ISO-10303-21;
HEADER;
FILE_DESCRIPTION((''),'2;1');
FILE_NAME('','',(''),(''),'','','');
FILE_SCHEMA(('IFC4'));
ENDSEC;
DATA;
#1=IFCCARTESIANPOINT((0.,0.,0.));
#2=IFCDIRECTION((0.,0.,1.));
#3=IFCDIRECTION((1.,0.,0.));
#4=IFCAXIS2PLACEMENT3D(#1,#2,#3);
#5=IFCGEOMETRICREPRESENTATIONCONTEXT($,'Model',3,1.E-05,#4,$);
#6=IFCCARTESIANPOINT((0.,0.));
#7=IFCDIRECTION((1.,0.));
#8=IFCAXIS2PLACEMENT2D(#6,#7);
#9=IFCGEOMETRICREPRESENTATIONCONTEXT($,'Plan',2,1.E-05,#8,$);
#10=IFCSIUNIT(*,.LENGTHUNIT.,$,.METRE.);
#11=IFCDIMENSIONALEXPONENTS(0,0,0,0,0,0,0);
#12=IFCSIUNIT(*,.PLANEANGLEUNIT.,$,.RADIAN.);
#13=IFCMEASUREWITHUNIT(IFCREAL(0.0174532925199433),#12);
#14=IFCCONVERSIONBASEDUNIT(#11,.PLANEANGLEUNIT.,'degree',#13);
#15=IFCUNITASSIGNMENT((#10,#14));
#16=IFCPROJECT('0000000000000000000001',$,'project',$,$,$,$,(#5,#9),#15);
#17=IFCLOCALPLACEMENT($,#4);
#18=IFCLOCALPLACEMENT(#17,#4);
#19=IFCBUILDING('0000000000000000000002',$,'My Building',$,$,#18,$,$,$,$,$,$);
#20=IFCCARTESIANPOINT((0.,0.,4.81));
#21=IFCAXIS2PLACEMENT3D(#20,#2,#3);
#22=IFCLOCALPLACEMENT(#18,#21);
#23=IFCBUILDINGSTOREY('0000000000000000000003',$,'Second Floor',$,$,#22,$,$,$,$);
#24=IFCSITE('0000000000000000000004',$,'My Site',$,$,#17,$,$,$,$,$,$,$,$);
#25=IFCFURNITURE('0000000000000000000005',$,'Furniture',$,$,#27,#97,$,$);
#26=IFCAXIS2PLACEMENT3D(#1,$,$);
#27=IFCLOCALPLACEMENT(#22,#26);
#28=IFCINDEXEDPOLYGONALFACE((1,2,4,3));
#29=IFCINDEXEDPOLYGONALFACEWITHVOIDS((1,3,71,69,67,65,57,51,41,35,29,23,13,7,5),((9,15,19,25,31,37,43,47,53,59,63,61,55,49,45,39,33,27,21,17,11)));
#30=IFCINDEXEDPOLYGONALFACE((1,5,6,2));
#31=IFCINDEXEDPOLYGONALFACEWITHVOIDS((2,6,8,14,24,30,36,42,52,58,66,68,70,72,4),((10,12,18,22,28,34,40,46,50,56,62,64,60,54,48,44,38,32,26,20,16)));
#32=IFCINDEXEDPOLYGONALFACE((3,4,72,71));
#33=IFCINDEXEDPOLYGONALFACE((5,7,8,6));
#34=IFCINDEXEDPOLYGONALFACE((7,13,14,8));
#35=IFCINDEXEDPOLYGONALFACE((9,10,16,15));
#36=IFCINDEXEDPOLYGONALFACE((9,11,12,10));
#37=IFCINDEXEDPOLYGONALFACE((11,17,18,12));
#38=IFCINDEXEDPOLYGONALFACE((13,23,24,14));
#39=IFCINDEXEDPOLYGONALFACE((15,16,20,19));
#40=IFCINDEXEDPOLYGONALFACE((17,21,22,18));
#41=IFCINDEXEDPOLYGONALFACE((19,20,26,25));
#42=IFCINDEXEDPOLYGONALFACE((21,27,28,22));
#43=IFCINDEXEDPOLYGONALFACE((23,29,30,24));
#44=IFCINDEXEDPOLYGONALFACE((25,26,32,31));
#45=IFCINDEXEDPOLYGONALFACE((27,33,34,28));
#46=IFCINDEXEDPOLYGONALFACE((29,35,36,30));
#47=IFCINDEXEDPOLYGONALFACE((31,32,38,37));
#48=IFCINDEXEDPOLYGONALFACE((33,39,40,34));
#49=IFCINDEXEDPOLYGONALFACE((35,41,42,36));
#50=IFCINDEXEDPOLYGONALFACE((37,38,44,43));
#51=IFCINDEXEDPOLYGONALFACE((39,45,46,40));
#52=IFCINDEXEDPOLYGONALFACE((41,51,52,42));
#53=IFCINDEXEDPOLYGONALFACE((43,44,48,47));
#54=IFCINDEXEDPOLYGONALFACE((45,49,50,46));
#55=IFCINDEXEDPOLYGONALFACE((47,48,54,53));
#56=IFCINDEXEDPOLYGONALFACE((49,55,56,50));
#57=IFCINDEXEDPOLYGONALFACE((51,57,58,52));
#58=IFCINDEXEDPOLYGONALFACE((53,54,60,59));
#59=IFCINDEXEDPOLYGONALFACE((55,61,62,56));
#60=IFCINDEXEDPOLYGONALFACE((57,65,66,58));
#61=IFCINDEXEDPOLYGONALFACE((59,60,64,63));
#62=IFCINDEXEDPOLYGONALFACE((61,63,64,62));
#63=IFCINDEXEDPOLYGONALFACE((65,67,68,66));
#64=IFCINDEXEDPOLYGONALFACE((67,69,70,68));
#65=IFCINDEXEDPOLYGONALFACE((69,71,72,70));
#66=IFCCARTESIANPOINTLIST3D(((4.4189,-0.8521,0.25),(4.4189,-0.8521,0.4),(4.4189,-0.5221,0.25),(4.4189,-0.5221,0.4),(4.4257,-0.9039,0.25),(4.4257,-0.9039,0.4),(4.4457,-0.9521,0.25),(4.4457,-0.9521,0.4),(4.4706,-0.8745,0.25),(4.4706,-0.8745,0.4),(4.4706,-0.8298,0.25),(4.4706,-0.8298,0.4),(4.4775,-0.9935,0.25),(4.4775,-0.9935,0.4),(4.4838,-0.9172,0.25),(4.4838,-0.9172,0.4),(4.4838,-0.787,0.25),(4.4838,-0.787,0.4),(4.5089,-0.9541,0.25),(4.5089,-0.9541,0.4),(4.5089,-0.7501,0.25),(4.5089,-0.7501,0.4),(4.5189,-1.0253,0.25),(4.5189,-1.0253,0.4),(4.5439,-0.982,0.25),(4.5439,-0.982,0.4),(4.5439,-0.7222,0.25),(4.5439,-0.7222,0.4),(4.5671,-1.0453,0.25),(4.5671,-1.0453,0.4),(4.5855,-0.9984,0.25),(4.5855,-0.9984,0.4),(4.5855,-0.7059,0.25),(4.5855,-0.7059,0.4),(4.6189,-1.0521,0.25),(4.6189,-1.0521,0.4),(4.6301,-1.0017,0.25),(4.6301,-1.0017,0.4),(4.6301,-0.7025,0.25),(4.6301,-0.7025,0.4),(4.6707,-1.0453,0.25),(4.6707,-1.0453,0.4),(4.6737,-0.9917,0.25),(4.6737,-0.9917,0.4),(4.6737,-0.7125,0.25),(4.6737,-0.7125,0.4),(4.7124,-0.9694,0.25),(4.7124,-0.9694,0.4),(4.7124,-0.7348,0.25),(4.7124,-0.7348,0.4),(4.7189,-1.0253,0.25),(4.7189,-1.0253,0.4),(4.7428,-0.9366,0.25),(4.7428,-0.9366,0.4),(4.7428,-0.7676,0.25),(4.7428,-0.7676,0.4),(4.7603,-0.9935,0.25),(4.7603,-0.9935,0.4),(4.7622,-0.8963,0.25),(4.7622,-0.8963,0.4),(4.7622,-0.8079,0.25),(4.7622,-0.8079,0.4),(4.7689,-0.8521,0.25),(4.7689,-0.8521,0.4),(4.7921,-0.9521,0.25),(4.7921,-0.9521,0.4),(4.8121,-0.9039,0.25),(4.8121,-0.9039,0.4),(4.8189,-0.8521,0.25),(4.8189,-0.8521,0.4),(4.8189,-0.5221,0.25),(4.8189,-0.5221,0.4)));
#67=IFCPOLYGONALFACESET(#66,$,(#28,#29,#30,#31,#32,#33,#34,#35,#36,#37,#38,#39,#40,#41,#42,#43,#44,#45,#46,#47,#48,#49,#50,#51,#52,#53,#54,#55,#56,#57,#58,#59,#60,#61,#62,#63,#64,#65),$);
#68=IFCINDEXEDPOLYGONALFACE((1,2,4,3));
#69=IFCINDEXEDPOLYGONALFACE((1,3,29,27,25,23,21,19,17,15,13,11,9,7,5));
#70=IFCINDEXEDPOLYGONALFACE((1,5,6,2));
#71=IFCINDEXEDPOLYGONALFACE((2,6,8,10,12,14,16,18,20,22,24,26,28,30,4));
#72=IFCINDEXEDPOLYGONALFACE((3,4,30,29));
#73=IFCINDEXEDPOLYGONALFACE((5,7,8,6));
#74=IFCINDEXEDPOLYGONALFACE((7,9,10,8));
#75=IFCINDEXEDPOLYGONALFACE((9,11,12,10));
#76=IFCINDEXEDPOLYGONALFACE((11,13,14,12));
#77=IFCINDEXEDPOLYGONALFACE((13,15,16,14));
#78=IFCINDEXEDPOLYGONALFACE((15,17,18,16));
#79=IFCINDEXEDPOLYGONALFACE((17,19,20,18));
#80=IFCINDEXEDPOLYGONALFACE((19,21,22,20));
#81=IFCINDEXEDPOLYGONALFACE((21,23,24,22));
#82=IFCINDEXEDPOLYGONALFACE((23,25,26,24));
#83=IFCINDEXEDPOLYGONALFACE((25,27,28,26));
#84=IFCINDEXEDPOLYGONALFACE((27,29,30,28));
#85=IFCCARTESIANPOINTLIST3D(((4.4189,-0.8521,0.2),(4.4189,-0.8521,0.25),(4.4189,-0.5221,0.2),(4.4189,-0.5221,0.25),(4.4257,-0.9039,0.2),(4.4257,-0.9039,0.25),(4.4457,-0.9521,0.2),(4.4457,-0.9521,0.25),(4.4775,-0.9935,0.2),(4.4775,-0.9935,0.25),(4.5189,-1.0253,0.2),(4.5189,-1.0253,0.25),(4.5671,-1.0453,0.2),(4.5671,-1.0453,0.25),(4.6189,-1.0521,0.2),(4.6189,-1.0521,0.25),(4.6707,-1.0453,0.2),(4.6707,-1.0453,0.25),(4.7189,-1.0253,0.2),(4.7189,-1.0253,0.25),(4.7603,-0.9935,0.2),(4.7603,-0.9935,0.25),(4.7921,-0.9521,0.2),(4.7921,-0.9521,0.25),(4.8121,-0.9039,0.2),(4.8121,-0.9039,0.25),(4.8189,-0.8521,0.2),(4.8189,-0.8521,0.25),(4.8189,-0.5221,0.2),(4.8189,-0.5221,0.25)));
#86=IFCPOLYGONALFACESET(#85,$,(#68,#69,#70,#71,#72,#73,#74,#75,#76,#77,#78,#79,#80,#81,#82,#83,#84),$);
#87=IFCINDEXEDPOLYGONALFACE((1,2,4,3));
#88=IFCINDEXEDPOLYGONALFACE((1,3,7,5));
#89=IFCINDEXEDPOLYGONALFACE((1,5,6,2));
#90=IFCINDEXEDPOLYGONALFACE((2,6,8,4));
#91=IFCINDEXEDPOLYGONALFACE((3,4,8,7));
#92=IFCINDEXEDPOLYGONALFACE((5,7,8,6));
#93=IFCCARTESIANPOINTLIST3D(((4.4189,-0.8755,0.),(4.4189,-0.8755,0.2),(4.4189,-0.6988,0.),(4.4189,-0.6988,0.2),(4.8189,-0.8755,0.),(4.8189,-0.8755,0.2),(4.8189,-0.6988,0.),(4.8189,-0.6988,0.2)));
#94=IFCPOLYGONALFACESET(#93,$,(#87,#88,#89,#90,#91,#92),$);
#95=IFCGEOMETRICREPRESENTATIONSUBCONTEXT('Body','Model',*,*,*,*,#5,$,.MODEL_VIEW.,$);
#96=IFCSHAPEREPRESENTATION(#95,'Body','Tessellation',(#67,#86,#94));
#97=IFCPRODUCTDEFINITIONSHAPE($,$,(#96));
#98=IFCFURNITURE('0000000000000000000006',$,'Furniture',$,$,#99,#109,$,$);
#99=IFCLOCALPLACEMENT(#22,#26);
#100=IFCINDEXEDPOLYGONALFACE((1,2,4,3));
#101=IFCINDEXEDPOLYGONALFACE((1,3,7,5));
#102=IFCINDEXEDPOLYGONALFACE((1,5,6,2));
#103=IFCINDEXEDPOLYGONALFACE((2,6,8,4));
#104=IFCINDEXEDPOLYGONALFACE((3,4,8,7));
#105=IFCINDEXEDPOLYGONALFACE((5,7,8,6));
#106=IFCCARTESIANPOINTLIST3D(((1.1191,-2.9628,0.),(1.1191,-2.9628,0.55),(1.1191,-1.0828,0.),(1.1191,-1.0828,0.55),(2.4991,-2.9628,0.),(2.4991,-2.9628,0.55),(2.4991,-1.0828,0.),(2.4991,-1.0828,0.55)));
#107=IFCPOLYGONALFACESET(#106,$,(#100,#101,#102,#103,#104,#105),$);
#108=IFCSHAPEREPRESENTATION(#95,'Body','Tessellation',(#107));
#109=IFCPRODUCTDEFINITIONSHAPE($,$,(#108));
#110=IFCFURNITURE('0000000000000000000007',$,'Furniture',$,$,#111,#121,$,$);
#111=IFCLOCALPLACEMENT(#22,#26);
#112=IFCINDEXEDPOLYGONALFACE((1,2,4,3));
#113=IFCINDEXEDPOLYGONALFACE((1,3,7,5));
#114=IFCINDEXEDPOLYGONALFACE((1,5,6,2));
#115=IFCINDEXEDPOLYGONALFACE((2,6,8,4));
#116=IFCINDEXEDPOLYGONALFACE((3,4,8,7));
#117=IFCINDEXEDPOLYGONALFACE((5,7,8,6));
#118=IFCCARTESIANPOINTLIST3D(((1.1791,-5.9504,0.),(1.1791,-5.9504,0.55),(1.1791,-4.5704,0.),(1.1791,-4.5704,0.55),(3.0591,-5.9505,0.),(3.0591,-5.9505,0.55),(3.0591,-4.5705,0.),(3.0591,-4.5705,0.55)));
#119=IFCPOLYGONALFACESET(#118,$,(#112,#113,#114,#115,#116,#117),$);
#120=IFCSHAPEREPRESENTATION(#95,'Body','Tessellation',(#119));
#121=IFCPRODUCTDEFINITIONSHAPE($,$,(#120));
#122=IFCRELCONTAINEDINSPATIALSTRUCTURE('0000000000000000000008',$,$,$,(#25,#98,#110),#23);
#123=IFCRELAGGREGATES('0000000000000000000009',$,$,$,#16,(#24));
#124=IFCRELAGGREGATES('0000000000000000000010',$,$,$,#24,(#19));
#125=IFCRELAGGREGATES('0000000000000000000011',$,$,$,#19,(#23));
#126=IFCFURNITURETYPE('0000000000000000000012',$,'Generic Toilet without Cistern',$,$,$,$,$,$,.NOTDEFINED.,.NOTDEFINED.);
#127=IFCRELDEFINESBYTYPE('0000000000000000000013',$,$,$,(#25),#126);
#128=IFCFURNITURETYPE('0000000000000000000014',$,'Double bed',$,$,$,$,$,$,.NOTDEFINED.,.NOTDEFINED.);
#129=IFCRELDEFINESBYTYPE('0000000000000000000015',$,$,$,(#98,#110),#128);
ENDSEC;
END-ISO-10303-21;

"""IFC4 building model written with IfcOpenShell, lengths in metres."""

from ifc_helpers import new_model, entity, si_unit, converted_unit, frame, frame_2d, origin_with_axes, origin_2d_with_axis, place, context, subcontext, project, spatial, line, arc, indexed_curve, circle_curve, outline, extrude, source, transform, mapped, type_object, type_shapes, element, save


model = new_model("IFC4")

# Units and contexts
model_context = context("Model", 3, precision=1e-05, world=origin_with_axes())
plan_context = context("Plan", 2, precision=1e-05, world=origin_2d_with_axis())
body_context = subcontext(model_context, "Body", "Model", "MODEL_VIEW")
ifc_project = project(units=[si_unit("LENGTHUNIT", "METRE"), converted_unit("PLANEANGLEUNIT", "degree", entity("IfcReal", 0.0174532925199433), si_unit("PLANEANGLEUNIT", "RADIAN"), dimensions=[0, 0, 0, 0, 0, 0, 0])], contexts=[model_context, plan_context])

# Site, building, storey
site_placement = place(None, origin_with_axes())
site = spatial("IfcSite", under=ifc_project, at=site_placement, Name="My Site")
building_placement = place(site_placement, origin_with_axes())
building = spatial("IfcBuilding", under=site, at=building_placement, Name="My Building")
storey_placement = place(building_placement, frame((0.0, 0.0, 4.81), z_axis=(0.0, 0.0, 1.0), x_axis=(1.0, 0.0, 0.0)))
storey = spatial("IfcBuildingStorey", under=building, at=storey_placement, Name="Second Floor")

# Furniture
furniture_type_1 = type_object("IfcFurnitureType", Name="Generic Toilet without Cistern", AssemblyPlace="NOTDEFINED", PredefinedType="NOTDEFINED")
shared_shape_1 = source(origin_with_axes(), body_context, "Body", "SweptSolid", [
    extrude(outline(indexed_curve([(-0.2, 0.0, 0.0), (-0.2, -0.33, 0.0), (-0.1414, -0.4714, 0.0), (0.0, -0.53, 0.0), (0.1414, -0.4714, 0.0), (0.2, -0.33, 0.0), (0.2, 0.0, 0.0)], segments=[line(1, 2), arc(2, 3, 4), arc(4, 5, 6), line(6, 7), line(1, 7)]), holes=[circle_curve(frame_2d((0.0, -0.33)), 0.15)]), frame((0.0, 0.0, 0.25), z_axis=(0.0, 0.0, 1.0), x_axis=(1.0, 0.0, 0.0)), (0.0, 0.0, 1.0), 0.15),
    extrude(outline(indexed_curve([(-0.2, 0.0, 0.0), (-0.2, -0.33, 0.0), (-0.1414, -0.4714, 0.0), (0.0, -0.53, 0.0), (0.1414, -0.4714, 0.0), (0.2, -0.33, 0.0), (0.2, 0.0, 0.0)], segments=[line(1, 2), arc(2, 3, 4), arc(4, 5, 6), line(6, 7), line(1, 7)])), frame((0.0, 0.0, 0.2), z_axis=(0.0, 0.0, 1.0), x_axis=(1.0, 0.0, 0.0)), (0.0, 0.0, 1.0), 0.05),
    extrude(outline(indexed_curve([(-0.2, -0.1767, 0.0), (-0.2, -0.3533, 0.0), (0.2, -0.3533, 0.0), (0.2, -0.1767, 0.0)], segments=[line(1, 2), line(2, 3), line(3, 4), line(4, 1)])), origin_with_axes(), (0.0, 0.0, 1.0), 0.2),
])
type_shapes(furniture_type_1, [shared_shape_1])
furniture_placement = place(storey_placement, frame((4.6189, -0.5221, 0.0), z_axis=(0.0, 0.0, 1.0), x_axis=(1.0, 0.0, 0.0)))
element("IfcFurniture", 1, at=furniture_placement, inside=storey, type_object=furniture_type_1, Name="Furniture", context=body_context, shape_type="MappedRepresentation", body=[
    mapped(shared_shape_1, transform((0.0, 0.0, 0.0), x_axis=(1.0, 0.0, 0.0), y_axis=(0.0, 1.0, 0.0), z_axis=(0.0, 0.0, 1.0), scale=1.0)),
])
furniture_type_2 = type_object("IfcFurnitureType", Name="Double bed", AssemblyPlace="NOTDEFINED", PredefinedType="NOTDEFINED")
shared_shape_2 = source(origin_with_axes(), body_context, "Body", "SweptSolid", [
    extrude(outline(indexed_curve([(0.0, 0.0), (0.0, 1.88), (1.38, 1.88), (1.38, 0.0)], segments=[line(1, 2), line(2, 3), line(3, 4), line(4, 1)])), origin_with_axes(), (0.0, 0.0, 1.0), 0.55),
])
type_shapes(furniture_type_2, [shared_shape_2])
for number, where, z_axis, x_axis, name in (
    (2, (2.4991, -1.0828, 0.0), (0.0, 0.0, 1.0), (-1.0, 0.0, 0.0), "Furniture"),
    (3, (1.1791, -4.5704, 0.0), (0.0, 0.0, 1.0), (0.0, -1.0, 0.0), "Furniture"),
):
    element("IfcFurniture", number, at=place(storey_placement, frame(where, z_axis=z_axis, x_axis=x_axis)), inside=storey, type_object=furniture_type_2, Name=name, context=body_context, shape_type="MappedRepresentation", body=[
        mapped(shared_shape_2, transform((0.0, 0.0, 0.0), x_axis=(1.0, 0.0, 0.0), y_axis=(0.0, 1.0, 0.0), z_axis=(0.0, 0.0, 1.0), scale=1.0)),
    ])

save(model, "model.ifc")
